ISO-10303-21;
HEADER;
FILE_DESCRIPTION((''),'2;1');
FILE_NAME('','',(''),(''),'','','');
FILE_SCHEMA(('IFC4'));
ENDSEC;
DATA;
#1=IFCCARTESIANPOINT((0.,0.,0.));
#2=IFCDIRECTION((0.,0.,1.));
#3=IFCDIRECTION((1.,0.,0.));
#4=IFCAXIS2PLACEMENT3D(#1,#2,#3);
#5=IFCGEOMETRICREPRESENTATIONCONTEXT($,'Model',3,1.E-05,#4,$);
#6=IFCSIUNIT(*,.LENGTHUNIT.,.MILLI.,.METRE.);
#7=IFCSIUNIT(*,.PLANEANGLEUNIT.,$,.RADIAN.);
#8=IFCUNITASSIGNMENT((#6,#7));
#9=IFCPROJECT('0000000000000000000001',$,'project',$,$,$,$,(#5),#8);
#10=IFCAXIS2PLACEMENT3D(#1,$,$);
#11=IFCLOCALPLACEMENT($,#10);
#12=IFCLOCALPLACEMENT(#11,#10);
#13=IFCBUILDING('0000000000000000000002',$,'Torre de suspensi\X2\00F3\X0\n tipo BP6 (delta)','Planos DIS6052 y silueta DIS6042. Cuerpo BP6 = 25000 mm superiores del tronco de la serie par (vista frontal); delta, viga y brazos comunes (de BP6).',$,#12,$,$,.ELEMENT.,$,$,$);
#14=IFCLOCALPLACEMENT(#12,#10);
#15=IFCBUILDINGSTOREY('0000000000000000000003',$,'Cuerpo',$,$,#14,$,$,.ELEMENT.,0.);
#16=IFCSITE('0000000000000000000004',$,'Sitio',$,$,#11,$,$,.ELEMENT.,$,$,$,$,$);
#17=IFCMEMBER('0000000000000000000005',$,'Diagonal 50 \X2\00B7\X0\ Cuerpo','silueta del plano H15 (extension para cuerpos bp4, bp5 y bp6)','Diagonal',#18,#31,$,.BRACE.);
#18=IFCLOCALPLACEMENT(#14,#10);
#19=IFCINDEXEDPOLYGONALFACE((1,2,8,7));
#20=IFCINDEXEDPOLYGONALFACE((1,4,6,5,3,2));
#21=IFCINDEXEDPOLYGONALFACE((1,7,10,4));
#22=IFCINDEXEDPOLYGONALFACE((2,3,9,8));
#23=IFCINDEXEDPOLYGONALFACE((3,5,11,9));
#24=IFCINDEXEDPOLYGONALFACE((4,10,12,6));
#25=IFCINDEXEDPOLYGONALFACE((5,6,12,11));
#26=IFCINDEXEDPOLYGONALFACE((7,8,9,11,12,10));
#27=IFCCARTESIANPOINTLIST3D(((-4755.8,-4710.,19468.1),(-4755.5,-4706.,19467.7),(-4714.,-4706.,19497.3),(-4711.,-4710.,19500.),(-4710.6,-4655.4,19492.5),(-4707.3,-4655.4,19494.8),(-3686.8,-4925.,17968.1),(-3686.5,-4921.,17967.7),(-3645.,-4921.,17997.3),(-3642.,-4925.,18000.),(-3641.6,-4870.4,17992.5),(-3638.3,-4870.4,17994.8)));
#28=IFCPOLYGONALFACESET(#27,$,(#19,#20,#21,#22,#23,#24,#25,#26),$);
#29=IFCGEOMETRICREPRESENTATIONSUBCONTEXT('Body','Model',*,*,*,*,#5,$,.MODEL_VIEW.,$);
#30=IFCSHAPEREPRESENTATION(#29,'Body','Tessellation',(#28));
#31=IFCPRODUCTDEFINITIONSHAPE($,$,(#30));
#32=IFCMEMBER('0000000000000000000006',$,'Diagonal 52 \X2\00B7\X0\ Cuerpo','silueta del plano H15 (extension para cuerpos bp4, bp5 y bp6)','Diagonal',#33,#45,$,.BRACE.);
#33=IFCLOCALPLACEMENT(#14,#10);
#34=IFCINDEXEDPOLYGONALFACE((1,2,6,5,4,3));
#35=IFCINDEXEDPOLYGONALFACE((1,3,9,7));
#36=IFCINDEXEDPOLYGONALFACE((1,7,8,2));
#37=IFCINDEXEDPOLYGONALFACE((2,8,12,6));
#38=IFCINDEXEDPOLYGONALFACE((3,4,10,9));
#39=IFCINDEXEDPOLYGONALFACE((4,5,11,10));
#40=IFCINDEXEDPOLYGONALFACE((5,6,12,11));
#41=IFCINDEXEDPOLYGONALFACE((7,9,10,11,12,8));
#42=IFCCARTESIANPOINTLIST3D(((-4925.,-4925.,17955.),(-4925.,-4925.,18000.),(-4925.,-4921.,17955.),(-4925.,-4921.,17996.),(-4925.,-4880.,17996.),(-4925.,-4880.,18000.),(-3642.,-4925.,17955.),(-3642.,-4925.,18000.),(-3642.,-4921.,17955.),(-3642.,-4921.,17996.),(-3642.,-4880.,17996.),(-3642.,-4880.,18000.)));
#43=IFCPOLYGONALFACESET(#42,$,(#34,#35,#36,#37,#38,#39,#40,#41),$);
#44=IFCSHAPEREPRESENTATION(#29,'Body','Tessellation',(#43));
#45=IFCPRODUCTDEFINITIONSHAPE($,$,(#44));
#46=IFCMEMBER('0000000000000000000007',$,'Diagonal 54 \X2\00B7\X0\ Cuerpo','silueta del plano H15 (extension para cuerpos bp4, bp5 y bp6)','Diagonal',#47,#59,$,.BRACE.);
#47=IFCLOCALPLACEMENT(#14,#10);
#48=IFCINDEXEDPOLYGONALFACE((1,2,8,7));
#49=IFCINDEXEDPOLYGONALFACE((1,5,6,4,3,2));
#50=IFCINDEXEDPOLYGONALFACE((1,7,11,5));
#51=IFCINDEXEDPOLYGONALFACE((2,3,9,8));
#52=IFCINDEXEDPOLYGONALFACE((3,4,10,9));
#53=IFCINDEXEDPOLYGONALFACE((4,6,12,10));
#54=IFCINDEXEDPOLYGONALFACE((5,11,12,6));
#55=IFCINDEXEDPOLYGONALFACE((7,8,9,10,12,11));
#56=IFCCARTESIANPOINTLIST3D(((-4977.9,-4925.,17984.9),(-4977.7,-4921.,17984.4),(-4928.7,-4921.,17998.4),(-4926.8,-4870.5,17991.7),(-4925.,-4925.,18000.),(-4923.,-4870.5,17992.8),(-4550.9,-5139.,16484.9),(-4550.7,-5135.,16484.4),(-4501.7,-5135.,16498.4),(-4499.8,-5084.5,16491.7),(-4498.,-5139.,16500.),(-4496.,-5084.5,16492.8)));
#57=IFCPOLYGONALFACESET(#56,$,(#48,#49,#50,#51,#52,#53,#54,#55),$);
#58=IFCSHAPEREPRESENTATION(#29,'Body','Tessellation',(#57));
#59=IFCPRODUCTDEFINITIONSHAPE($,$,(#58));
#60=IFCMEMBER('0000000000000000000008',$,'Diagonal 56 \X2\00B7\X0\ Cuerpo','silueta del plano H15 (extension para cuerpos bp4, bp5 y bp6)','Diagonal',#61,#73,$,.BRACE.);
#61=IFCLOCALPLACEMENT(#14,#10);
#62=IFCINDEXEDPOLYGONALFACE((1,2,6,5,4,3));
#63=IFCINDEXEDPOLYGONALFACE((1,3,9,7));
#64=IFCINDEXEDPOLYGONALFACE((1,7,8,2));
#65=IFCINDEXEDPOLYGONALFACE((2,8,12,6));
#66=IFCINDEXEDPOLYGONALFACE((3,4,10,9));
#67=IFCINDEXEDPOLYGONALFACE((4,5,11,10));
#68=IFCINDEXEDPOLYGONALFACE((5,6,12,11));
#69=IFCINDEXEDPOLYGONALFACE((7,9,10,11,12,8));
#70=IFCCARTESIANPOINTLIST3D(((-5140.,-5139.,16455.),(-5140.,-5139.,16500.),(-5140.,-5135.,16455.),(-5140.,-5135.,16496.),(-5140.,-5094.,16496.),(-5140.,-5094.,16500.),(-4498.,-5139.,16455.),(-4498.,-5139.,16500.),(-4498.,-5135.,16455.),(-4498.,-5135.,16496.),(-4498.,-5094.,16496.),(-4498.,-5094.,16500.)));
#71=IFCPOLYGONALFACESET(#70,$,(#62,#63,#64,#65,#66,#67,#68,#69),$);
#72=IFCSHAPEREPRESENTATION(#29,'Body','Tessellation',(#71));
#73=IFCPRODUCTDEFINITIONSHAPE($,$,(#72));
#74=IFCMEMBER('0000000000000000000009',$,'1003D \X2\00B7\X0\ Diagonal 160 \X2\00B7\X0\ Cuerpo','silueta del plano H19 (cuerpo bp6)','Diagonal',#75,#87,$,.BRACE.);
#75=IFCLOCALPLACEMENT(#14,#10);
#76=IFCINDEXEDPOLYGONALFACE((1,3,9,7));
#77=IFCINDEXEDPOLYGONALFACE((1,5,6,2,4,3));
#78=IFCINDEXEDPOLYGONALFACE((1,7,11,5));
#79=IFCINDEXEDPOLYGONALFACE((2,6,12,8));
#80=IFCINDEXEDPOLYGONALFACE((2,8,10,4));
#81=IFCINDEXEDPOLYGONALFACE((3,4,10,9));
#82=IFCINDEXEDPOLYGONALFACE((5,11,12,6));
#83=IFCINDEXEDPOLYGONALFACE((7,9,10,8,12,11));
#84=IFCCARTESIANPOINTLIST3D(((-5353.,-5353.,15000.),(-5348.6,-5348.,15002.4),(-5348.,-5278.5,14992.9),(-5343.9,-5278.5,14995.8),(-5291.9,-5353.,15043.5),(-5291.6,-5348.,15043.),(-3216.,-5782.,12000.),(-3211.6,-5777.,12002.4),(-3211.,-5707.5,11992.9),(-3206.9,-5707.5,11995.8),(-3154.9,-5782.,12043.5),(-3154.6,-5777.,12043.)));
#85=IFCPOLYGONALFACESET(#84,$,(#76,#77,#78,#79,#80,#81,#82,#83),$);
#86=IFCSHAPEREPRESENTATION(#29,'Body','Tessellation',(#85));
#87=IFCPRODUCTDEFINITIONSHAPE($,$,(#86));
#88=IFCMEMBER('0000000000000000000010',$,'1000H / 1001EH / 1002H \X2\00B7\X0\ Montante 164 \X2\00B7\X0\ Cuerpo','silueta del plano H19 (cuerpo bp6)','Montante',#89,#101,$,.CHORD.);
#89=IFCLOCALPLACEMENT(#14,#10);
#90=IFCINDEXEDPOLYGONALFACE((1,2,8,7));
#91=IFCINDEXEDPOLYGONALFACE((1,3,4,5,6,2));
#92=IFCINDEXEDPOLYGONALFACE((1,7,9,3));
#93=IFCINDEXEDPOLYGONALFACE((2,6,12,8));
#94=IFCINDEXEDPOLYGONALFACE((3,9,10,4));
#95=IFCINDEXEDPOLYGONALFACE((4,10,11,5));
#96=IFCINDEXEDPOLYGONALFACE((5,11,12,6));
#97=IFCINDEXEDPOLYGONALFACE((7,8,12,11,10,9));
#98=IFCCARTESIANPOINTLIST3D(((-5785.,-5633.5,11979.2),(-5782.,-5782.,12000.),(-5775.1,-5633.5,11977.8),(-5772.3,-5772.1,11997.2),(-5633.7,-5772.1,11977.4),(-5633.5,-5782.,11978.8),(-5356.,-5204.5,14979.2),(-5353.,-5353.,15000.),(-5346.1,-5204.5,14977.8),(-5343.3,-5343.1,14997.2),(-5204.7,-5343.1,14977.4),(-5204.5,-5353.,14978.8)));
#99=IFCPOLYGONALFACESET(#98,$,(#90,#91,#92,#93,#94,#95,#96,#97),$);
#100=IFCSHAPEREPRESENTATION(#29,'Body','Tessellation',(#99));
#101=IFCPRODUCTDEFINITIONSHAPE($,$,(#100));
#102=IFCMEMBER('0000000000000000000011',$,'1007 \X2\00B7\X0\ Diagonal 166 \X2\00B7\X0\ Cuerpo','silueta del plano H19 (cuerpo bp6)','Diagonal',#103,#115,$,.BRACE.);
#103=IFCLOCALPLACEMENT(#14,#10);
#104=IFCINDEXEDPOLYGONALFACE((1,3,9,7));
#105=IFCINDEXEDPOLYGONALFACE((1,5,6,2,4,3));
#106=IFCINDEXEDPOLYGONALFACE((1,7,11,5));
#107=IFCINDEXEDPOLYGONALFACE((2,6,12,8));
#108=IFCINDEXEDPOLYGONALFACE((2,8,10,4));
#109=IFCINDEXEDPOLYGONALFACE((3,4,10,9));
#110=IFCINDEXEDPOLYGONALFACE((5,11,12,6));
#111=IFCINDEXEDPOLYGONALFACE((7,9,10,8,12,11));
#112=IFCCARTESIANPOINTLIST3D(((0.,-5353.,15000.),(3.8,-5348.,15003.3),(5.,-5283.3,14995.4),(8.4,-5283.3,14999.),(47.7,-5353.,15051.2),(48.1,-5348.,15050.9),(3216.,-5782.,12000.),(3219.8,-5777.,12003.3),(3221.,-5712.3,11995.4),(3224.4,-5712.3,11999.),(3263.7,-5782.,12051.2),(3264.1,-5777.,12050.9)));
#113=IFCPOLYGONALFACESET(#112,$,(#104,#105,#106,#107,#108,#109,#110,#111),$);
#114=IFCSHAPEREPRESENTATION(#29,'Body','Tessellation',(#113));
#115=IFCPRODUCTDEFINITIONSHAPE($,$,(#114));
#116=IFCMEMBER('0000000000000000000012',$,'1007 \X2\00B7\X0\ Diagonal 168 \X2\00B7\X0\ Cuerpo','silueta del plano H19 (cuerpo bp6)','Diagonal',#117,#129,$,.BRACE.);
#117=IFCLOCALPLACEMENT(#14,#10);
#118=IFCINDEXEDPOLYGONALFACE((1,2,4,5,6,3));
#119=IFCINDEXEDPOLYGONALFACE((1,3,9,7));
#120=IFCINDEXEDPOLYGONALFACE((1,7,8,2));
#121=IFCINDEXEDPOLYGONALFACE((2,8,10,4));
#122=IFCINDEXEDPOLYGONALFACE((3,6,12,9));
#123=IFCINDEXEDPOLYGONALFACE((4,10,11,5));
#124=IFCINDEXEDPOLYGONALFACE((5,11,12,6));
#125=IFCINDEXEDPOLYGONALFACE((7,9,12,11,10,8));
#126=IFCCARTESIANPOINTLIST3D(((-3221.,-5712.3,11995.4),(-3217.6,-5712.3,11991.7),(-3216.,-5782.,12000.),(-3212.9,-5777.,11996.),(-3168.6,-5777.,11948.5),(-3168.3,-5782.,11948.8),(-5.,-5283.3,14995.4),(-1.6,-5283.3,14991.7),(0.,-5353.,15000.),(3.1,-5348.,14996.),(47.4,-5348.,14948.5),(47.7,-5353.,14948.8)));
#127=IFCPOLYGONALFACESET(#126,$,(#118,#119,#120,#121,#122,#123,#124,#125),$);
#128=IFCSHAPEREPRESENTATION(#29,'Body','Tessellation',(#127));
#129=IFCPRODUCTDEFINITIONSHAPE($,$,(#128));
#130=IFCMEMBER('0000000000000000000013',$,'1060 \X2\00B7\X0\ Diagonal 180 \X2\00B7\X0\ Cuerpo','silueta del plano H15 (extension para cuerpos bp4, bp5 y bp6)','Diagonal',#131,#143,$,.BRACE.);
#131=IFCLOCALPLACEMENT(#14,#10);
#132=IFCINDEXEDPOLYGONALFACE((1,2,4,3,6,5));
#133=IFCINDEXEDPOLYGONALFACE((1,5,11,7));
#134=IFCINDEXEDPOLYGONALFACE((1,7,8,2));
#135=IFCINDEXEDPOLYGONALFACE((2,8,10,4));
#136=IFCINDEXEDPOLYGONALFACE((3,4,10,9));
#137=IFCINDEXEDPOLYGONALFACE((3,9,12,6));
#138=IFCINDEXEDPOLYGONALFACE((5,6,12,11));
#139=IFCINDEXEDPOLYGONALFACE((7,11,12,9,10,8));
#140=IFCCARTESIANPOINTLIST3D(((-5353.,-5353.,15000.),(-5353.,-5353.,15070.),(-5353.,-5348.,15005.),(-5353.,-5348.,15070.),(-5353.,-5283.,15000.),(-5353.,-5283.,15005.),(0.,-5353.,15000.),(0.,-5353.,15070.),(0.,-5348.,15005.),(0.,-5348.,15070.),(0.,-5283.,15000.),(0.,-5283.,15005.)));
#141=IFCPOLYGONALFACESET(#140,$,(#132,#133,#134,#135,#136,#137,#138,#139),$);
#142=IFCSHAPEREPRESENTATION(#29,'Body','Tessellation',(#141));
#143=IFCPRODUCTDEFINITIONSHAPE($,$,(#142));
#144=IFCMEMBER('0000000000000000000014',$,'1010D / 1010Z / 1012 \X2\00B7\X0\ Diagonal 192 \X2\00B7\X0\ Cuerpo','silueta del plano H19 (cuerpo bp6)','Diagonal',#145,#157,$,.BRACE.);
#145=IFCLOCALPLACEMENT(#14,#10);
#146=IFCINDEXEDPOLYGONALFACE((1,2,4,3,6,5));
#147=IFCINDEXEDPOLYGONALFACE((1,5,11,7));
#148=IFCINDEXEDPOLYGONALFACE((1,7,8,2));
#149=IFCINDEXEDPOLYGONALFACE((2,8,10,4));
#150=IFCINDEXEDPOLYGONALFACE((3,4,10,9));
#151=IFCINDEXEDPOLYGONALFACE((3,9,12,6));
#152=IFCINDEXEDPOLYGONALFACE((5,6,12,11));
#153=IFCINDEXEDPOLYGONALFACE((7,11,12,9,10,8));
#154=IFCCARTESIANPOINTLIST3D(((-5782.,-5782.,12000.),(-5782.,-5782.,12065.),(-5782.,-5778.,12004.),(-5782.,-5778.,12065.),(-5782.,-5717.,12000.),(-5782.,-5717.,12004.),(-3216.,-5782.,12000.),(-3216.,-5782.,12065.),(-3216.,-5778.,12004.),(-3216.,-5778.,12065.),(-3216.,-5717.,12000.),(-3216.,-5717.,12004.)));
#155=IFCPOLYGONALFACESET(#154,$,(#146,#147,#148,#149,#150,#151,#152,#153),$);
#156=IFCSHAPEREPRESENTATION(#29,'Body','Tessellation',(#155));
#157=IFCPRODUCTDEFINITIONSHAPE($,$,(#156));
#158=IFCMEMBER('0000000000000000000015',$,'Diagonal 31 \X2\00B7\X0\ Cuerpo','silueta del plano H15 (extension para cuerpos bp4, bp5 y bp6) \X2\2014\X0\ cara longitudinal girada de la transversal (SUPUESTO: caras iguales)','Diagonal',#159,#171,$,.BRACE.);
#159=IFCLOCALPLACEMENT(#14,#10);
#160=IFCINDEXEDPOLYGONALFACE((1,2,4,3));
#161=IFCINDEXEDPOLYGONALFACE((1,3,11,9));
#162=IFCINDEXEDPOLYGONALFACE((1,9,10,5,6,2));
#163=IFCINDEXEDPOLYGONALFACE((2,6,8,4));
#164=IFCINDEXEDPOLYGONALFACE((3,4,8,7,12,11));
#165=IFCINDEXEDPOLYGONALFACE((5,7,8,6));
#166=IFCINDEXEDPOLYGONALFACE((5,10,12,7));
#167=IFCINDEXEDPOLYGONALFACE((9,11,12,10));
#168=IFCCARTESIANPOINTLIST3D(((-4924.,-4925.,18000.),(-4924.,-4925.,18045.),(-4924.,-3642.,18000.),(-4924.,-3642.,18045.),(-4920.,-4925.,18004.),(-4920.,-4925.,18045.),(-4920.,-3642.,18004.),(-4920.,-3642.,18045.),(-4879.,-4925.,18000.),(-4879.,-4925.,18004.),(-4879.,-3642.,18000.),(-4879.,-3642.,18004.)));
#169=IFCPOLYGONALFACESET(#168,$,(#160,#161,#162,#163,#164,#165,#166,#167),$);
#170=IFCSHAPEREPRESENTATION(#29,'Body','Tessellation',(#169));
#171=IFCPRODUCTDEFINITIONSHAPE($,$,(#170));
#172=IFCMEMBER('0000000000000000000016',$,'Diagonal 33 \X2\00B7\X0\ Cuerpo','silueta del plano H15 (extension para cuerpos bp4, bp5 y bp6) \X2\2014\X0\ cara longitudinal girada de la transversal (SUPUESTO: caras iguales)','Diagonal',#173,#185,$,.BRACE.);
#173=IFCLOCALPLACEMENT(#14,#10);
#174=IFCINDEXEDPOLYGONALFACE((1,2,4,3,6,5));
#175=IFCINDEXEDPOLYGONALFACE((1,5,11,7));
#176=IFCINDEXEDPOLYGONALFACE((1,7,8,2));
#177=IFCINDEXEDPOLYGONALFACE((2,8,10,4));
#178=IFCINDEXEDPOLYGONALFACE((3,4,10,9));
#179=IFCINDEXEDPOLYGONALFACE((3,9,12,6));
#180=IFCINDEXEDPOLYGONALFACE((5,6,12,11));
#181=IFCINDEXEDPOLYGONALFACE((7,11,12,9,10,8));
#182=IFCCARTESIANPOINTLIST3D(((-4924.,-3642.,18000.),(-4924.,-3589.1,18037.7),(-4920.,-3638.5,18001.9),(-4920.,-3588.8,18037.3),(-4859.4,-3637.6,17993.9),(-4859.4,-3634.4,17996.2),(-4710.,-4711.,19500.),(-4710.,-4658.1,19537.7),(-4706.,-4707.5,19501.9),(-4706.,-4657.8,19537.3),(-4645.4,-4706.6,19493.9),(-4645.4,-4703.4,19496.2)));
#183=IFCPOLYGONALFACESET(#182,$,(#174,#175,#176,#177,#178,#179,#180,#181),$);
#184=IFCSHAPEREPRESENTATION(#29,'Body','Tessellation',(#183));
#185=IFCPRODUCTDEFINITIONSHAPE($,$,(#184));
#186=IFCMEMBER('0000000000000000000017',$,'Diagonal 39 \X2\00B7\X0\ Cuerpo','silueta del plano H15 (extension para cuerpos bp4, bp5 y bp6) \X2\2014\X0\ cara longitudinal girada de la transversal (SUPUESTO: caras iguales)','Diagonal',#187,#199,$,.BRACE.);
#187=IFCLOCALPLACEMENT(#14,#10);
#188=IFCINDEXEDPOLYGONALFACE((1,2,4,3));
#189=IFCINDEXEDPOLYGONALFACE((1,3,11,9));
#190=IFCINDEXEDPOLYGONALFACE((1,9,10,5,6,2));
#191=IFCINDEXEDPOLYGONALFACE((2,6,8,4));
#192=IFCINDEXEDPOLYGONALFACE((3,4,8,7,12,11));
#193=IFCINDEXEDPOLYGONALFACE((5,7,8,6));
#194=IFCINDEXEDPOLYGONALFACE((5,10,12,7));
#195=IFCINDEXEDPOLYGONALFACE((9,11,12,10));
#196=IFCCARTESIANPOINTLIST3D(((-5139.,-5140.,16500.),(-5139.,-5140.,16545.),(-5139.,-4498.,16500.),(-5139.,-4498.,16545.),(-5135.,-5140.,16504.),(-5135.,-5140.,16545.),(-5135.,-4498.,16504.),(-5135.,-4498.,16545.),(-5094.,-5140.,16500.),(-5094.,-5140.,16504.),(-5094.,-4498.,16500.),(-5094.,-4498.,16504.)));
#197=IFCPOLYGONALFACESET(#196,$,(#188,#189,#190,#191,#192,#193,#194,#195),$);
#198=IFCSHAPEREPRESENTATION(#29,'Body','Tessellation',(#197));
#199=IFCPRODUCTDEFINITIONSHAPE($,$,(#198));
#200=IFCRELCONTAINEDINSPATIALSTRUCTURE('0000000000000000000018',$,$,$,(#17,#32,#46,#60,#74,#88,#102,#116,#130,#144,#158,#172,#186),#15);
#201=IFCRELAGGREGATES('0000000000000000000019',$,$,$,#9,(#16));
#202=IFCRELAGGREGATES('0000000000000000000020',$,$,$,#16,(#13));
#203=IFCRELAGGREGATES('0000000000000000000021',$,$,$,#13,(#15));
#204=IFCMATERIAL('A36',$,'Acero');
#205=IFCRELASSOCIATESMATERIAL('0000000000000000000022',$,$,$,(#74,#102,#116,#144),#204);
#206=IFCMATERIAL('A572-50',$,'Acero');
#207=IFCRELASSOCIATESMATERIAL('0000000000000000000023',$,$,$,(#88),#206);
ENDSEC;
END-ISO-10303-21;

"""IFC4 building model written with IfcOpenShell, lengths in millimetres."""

from ifc_helpers import new_model, si_unit, frame, frame_2d, origin, origin_with_axes, place, context, subcontext, project, spatial, l_section, extrude, material, element, save


model = new_model("IFC4")

# Units and contexts
model_context = context("Model", 3, precision=1e-05, world=origin_with_axes())
body_context = subcontext(model_context, "Body", "Model", "MODEL_VIEW")
ifc_project = project(units=[si_unit("LENGTHUNIT", "METRE", prefix="MILLI"), si_unit("PLANEANGLEUNIT", "RADIAN")], contexts=[model_context])

# Site, building, storey
site_placement = place(None, origin())
site = spatial("IfcSite", under=ifc_project, at=site_placement, Name="Sitio", CompositionType="ELEMENT")
building_placement = place(site_placement, origin())
building = spatial("IfcBuilding", under=site, at=building_placement, Name="Torre de suspensión tipo BP6 (delta)", Description="Planos DIS6052 y silueta DIS6042. Cuerpo BP6 = 25000 mm superiores del tronco de la serie par (vista frontal); delta, viga y brazos comunes (de BP6).", CompositionType="ELEMENT")
storey_placement = place(building_placement, origin())
storey = spatial("IfcBuildingStorey", under=building, at=storey_placement, Name="Cuerpo", CompositionType="ELEMENT", Elevation=0.0)

# Members
member_1_placement = place(storey_placement, frame((-3642.0, -4925.0, 18000.0), z_axis=(-0.576451, 0.115937, 0.808865), x_axis=(0.067286, 0.993257, -0.094414)))
element("IfcMember", 1, at=member_1_placement, inside=storey, Name="Diagonal 50 · Cuerpo", Description="silueta del plano H15 (extension para cuerpos bp4, bp5 y bp6)", ObjectType="Diagonal", PredefinedType="BRACE", context=body_context, shape_type="SweptSolid", body=[
    extrude(l_section(Depth=55.0, Width=55.0, Thickness=4.0, at=frame_2d((27.5, 27.5))), None, (0.0, 0.0, 1.0), 1854.5),
])
member_2_placement = place(storey_placement, frame((-3642.0, -4925.0, 18000.0), z_axis=(-1.0, 0.0, 0.0), x_axis=(0.0, 1.0, 0.0)))
element("IfcMember", 2, at=member_2_placement, inside=storey, Name="Diagonal 52 · Cuerpo", Description="silueta del plano H15 (extension para cuerpos bp4, bp5 y bp6)", ObjectType="Diagonal", PredefinedType="BRACE", context=body_context, shape_type="SweptSolid", body=[
    extrude(l_section(Depth=45.0, Width=45.0, Thickness=4.0, at=frame_2d((22.5, 22.5))), None, (0.0, 0.0, 1.0), 1283.0),
])
member_3_placement = place(storey_placement, frame((-4498.0, -5139.0, 16500.0), z_axis=(-0.271248, 0.135942, 0.952861), x_axis=(0.037219, 0.990717, -0.130747)))
element("IfcMember", 3, at=member_3_placement, inside=storey, Name="Diagonal 54 · Cuerpo", Description="silueta del plano H15 (extension para cuerpos bp4, bp5 y bp6)", ObjectType="Diagonal", PredefinedType="BRACE", context=body_context, shape_type="SweptSolid", body=[
    extrude(l_section(Depth=55.0, Width=55.0, Thickness=4.0, at=frame_2d((27.5, 27.5))), None, (0.0, 0.0, 1.0), 1574.2),
])
member_4_placement = place(storey_placement, frame((-4498.0, -5139.0, 16500.0), z_axis=(-1.0, 0.0, 0.0), x_axis=(0.0, 1.0, 0.0)))
element("IfcMember", 4, at=member_4_placement, inside=storey, Name="Diagonal 56 · Cuerpo", Description="silueta del plano H15 (extension para cuerpos bp4, bp5 y bp6)", ObjectType="Diagonal", PredefinedType="BRACE", context=body_context, shape_type="SweptSolid", body=[
    extrude(l_section(Depth=45.0, Width=45.0, Thickness=4.0, at=frame_2d((22.5, 22.5))), None, (0.0, 0.0, 1.0), 642.0),
])
ifc_material_1 = material(Name="A36", Category="Acero")
member_5_placement = place(storey_placement, frame((-5353.0, -5353.0, 15000.0), z_axis=(0.576289, -0.115689, -0.809016), x_axis=(0.067121, 0.993285, -0.094227)))
element("IfcMember", 5, at=member_5_placement, inside=storey, material=ifc_material_1, Name="1003D · Diagonal 160 · Cuerpo", Description="silueta del plano H19 (cuerpo bp6)", ObjectType="Diagonal", PredefinedType="BRACE", context=body_context, shape_type="SweptSolid", body=[
    extrude(l_section(Depth=75.0, Width=75.0, Thickness=5.0, at=frame_2d((37.5, 37.5))), None, (0.0, 0.0, 1.0), 3708.2),
])
ifc_material_2 = material(Name="A572-50", Category="Acero")
member_6_placement = place(storey_placement, frame((-5353.0, -5353.0, 15000.0), z_axis=(-0.140163, -0.140163, -0.980158), x_axis=(-0.019841, 0.990129, -0.138751)))
element("IfcMember", 6, at=member_6_placement, inside=storey, material=ifc_material_2, Name="1000H / 1001EH / 1002H · Montante 164 · Cuerpo", Description="silueta del plano H19 (cuerpo bp6)", ObjectType="Montante", PredefinedType="CHORD", context=body_context, shape_type="SweptSolid", body=[
    extrude(l_section(Depth=150.0, Width=150.0, Thickness=10.0, at=frame_2d((75.0, 75.0))), None, (0.0, 0.0, 1.0), 3060.7),
])
for number, where, z_axis, x_axis, name in (
    (7, (0.0, -5353.0, 15000.0), (0.727783, -0.097083, -0.678902), (0.070991, 0.995276, -0.066223), "1007 · Diagonal 166 · Cuerpo"),
    (8, (0.0, -5353.0, 15000.0), (-0.727783, -0.097083, -0.678902), (-0.070991, 0.995276, -0.066223), "1007 · Diagonal 168 · Cuerpo"),
):
    element("IfcMember", number, at=place(storey_placement, frame(where, z_axis=z_axis, x_axis=x_axis)), inside=storey, material=ifc_material_1, Name=name, Description="silueta del plano H19 (cuerpo bp6)", ObjectType="Diagonal", PredefinedType="BRACE", context=body_context, shape_type="SweptSolid", body=[
        extrude(l_section(Depth=70.0, Width=70.0, Thickness=5.0, at=frame_2d((35.0, 35.0))), None, (0.0, 0.0, 1.0), 4418.9),
    ])
member_7_placement = place(storey_placement, frame((-5353.0, -5353.0, 15000.0), z_axis=(1.0, 0.0, 0.0), x_axis=(0.0, 1.0, 0.0)))
element("IfcMember", 9, at=member_7_placement, inside=storey, Name="1060 · Diagonal 180 · Cuerpo", Description="silueta del plano H15 (extension para cuerpos bp4, bp5 y bp6)", ObjectType="Diagonal", PredefinedType="BRACE", context=body_context, shape_type="SweptSolid", body=[
    extrude(l_section(Depth=70.0, Width=70.0, Thickness=5.0, at=frame_2d((35.0, 35.0))), None, (0.0, 0.0, 1.0), 5353.0),
])
member_8_placement = place(storey_placement, frame((-5782.0, -5782.0, 12000.0), z_axis=(1.0, 0.0, 0.0), x_axis=(0.0, 1.0, 0.0)))
element("IfcMember", 10, at=member_8_placement, inside=storey, material=ifc_material_1, Name="1010D / 1010Z / 1012 · Diagonal 192 · Cuerpo", Description="silueta del plano H19 (cuerpo bp6)", ObjectType="Diagonal", PredefinedType="BRACE", context=body_context, shape_type="SweptSolid", body=[
    extrude(l_section(Depth=65.0, Width=65.0, Thickness=4.0, at=frame_2d((32.5, 32.5))), None, (0.0, 0.0, 1.0), 2566.0),
])
member_9_placement = place(storey_placement, frame((-4924.0, -3642.0, 18000.0), z_axis=(0.0, -1.0, 0.0), x_axis=(1.0, 0.0, 0.0)))
element("IfcMember", 11, at=member_9_placement, inside=storey, Name="Diagonal 31 · Cuerpo", Description="silueta del plano H15 (extension para cuerpos bp4, bp5 y bp6) — cara longitudinal girada de la transversal (SUPUESTO: caras iguales)", ObjectType="Diagonal", PredefinedType="BRACE", context=body_context, shape_type="SweptSolid", body=[
    extrude(l_section(Depth=45.0, Width=45.0, Thickness=4.0, at=frame_2d((22.5, 22.5))), None, (0.0, 0.0, 1.0), 1283.0),
])
member_10_placement = place(storey_placement, frame((-4924.0, -3642.0, 18000.0), z_axis=(0.115405, -0.576487, 0.808915), x_axis=(0.993318, 0.066977, -0.093981)))
element("IfcMember", 12, at=member_10_placement, inside=storey, Name="Diagonal 33 · Cuerpo", Description="silueta del plano H15 (extension para cuerpos bp4, bp5 y bp6) — cara longitudinal girada de la transversal (SUPUESTO: caras iguales)", ObjectType="Diagonal", PredefinedType="BRACE", context=body_context, shape_type="SweptSolid", body=[
    extrude(l_section(Depth=65.0, Width=65.0, Thickness=4.0, at=frame_2d((32.5, 32.5))), None, (0.0, 0.0, 1.0), 1854.3),
])
member_11_placement = place(storey_placement, frame((-5139.0, -4498.0, 16500.0), z_axis=(0.0, -1.0, 0.0), x_axis=(1.0, 0.0, 0.0)))
element("IfcMember", 13, at=member_11_placement, inside=storey, Name="Diagonal 39 · Cuerpo", Description="silueta del plano H15 (extension para cuerpos bp4, bp5 y bp6) — cara longitudinal girada de la transversal (SUPUESTO: caras iguales)", ObjectType="Diagonal", PredefinedType="BRACE", context=body_context, shape_type="SweptSolid", body=[
    extrude(l_section(Depth=45.0, Width=45.0, Thickness=4.0, at=frame_2d((22.5, 22.5))), None, (0.0, 0.0, 1.0), 642.0),
])

save(model, "model.ifc")
